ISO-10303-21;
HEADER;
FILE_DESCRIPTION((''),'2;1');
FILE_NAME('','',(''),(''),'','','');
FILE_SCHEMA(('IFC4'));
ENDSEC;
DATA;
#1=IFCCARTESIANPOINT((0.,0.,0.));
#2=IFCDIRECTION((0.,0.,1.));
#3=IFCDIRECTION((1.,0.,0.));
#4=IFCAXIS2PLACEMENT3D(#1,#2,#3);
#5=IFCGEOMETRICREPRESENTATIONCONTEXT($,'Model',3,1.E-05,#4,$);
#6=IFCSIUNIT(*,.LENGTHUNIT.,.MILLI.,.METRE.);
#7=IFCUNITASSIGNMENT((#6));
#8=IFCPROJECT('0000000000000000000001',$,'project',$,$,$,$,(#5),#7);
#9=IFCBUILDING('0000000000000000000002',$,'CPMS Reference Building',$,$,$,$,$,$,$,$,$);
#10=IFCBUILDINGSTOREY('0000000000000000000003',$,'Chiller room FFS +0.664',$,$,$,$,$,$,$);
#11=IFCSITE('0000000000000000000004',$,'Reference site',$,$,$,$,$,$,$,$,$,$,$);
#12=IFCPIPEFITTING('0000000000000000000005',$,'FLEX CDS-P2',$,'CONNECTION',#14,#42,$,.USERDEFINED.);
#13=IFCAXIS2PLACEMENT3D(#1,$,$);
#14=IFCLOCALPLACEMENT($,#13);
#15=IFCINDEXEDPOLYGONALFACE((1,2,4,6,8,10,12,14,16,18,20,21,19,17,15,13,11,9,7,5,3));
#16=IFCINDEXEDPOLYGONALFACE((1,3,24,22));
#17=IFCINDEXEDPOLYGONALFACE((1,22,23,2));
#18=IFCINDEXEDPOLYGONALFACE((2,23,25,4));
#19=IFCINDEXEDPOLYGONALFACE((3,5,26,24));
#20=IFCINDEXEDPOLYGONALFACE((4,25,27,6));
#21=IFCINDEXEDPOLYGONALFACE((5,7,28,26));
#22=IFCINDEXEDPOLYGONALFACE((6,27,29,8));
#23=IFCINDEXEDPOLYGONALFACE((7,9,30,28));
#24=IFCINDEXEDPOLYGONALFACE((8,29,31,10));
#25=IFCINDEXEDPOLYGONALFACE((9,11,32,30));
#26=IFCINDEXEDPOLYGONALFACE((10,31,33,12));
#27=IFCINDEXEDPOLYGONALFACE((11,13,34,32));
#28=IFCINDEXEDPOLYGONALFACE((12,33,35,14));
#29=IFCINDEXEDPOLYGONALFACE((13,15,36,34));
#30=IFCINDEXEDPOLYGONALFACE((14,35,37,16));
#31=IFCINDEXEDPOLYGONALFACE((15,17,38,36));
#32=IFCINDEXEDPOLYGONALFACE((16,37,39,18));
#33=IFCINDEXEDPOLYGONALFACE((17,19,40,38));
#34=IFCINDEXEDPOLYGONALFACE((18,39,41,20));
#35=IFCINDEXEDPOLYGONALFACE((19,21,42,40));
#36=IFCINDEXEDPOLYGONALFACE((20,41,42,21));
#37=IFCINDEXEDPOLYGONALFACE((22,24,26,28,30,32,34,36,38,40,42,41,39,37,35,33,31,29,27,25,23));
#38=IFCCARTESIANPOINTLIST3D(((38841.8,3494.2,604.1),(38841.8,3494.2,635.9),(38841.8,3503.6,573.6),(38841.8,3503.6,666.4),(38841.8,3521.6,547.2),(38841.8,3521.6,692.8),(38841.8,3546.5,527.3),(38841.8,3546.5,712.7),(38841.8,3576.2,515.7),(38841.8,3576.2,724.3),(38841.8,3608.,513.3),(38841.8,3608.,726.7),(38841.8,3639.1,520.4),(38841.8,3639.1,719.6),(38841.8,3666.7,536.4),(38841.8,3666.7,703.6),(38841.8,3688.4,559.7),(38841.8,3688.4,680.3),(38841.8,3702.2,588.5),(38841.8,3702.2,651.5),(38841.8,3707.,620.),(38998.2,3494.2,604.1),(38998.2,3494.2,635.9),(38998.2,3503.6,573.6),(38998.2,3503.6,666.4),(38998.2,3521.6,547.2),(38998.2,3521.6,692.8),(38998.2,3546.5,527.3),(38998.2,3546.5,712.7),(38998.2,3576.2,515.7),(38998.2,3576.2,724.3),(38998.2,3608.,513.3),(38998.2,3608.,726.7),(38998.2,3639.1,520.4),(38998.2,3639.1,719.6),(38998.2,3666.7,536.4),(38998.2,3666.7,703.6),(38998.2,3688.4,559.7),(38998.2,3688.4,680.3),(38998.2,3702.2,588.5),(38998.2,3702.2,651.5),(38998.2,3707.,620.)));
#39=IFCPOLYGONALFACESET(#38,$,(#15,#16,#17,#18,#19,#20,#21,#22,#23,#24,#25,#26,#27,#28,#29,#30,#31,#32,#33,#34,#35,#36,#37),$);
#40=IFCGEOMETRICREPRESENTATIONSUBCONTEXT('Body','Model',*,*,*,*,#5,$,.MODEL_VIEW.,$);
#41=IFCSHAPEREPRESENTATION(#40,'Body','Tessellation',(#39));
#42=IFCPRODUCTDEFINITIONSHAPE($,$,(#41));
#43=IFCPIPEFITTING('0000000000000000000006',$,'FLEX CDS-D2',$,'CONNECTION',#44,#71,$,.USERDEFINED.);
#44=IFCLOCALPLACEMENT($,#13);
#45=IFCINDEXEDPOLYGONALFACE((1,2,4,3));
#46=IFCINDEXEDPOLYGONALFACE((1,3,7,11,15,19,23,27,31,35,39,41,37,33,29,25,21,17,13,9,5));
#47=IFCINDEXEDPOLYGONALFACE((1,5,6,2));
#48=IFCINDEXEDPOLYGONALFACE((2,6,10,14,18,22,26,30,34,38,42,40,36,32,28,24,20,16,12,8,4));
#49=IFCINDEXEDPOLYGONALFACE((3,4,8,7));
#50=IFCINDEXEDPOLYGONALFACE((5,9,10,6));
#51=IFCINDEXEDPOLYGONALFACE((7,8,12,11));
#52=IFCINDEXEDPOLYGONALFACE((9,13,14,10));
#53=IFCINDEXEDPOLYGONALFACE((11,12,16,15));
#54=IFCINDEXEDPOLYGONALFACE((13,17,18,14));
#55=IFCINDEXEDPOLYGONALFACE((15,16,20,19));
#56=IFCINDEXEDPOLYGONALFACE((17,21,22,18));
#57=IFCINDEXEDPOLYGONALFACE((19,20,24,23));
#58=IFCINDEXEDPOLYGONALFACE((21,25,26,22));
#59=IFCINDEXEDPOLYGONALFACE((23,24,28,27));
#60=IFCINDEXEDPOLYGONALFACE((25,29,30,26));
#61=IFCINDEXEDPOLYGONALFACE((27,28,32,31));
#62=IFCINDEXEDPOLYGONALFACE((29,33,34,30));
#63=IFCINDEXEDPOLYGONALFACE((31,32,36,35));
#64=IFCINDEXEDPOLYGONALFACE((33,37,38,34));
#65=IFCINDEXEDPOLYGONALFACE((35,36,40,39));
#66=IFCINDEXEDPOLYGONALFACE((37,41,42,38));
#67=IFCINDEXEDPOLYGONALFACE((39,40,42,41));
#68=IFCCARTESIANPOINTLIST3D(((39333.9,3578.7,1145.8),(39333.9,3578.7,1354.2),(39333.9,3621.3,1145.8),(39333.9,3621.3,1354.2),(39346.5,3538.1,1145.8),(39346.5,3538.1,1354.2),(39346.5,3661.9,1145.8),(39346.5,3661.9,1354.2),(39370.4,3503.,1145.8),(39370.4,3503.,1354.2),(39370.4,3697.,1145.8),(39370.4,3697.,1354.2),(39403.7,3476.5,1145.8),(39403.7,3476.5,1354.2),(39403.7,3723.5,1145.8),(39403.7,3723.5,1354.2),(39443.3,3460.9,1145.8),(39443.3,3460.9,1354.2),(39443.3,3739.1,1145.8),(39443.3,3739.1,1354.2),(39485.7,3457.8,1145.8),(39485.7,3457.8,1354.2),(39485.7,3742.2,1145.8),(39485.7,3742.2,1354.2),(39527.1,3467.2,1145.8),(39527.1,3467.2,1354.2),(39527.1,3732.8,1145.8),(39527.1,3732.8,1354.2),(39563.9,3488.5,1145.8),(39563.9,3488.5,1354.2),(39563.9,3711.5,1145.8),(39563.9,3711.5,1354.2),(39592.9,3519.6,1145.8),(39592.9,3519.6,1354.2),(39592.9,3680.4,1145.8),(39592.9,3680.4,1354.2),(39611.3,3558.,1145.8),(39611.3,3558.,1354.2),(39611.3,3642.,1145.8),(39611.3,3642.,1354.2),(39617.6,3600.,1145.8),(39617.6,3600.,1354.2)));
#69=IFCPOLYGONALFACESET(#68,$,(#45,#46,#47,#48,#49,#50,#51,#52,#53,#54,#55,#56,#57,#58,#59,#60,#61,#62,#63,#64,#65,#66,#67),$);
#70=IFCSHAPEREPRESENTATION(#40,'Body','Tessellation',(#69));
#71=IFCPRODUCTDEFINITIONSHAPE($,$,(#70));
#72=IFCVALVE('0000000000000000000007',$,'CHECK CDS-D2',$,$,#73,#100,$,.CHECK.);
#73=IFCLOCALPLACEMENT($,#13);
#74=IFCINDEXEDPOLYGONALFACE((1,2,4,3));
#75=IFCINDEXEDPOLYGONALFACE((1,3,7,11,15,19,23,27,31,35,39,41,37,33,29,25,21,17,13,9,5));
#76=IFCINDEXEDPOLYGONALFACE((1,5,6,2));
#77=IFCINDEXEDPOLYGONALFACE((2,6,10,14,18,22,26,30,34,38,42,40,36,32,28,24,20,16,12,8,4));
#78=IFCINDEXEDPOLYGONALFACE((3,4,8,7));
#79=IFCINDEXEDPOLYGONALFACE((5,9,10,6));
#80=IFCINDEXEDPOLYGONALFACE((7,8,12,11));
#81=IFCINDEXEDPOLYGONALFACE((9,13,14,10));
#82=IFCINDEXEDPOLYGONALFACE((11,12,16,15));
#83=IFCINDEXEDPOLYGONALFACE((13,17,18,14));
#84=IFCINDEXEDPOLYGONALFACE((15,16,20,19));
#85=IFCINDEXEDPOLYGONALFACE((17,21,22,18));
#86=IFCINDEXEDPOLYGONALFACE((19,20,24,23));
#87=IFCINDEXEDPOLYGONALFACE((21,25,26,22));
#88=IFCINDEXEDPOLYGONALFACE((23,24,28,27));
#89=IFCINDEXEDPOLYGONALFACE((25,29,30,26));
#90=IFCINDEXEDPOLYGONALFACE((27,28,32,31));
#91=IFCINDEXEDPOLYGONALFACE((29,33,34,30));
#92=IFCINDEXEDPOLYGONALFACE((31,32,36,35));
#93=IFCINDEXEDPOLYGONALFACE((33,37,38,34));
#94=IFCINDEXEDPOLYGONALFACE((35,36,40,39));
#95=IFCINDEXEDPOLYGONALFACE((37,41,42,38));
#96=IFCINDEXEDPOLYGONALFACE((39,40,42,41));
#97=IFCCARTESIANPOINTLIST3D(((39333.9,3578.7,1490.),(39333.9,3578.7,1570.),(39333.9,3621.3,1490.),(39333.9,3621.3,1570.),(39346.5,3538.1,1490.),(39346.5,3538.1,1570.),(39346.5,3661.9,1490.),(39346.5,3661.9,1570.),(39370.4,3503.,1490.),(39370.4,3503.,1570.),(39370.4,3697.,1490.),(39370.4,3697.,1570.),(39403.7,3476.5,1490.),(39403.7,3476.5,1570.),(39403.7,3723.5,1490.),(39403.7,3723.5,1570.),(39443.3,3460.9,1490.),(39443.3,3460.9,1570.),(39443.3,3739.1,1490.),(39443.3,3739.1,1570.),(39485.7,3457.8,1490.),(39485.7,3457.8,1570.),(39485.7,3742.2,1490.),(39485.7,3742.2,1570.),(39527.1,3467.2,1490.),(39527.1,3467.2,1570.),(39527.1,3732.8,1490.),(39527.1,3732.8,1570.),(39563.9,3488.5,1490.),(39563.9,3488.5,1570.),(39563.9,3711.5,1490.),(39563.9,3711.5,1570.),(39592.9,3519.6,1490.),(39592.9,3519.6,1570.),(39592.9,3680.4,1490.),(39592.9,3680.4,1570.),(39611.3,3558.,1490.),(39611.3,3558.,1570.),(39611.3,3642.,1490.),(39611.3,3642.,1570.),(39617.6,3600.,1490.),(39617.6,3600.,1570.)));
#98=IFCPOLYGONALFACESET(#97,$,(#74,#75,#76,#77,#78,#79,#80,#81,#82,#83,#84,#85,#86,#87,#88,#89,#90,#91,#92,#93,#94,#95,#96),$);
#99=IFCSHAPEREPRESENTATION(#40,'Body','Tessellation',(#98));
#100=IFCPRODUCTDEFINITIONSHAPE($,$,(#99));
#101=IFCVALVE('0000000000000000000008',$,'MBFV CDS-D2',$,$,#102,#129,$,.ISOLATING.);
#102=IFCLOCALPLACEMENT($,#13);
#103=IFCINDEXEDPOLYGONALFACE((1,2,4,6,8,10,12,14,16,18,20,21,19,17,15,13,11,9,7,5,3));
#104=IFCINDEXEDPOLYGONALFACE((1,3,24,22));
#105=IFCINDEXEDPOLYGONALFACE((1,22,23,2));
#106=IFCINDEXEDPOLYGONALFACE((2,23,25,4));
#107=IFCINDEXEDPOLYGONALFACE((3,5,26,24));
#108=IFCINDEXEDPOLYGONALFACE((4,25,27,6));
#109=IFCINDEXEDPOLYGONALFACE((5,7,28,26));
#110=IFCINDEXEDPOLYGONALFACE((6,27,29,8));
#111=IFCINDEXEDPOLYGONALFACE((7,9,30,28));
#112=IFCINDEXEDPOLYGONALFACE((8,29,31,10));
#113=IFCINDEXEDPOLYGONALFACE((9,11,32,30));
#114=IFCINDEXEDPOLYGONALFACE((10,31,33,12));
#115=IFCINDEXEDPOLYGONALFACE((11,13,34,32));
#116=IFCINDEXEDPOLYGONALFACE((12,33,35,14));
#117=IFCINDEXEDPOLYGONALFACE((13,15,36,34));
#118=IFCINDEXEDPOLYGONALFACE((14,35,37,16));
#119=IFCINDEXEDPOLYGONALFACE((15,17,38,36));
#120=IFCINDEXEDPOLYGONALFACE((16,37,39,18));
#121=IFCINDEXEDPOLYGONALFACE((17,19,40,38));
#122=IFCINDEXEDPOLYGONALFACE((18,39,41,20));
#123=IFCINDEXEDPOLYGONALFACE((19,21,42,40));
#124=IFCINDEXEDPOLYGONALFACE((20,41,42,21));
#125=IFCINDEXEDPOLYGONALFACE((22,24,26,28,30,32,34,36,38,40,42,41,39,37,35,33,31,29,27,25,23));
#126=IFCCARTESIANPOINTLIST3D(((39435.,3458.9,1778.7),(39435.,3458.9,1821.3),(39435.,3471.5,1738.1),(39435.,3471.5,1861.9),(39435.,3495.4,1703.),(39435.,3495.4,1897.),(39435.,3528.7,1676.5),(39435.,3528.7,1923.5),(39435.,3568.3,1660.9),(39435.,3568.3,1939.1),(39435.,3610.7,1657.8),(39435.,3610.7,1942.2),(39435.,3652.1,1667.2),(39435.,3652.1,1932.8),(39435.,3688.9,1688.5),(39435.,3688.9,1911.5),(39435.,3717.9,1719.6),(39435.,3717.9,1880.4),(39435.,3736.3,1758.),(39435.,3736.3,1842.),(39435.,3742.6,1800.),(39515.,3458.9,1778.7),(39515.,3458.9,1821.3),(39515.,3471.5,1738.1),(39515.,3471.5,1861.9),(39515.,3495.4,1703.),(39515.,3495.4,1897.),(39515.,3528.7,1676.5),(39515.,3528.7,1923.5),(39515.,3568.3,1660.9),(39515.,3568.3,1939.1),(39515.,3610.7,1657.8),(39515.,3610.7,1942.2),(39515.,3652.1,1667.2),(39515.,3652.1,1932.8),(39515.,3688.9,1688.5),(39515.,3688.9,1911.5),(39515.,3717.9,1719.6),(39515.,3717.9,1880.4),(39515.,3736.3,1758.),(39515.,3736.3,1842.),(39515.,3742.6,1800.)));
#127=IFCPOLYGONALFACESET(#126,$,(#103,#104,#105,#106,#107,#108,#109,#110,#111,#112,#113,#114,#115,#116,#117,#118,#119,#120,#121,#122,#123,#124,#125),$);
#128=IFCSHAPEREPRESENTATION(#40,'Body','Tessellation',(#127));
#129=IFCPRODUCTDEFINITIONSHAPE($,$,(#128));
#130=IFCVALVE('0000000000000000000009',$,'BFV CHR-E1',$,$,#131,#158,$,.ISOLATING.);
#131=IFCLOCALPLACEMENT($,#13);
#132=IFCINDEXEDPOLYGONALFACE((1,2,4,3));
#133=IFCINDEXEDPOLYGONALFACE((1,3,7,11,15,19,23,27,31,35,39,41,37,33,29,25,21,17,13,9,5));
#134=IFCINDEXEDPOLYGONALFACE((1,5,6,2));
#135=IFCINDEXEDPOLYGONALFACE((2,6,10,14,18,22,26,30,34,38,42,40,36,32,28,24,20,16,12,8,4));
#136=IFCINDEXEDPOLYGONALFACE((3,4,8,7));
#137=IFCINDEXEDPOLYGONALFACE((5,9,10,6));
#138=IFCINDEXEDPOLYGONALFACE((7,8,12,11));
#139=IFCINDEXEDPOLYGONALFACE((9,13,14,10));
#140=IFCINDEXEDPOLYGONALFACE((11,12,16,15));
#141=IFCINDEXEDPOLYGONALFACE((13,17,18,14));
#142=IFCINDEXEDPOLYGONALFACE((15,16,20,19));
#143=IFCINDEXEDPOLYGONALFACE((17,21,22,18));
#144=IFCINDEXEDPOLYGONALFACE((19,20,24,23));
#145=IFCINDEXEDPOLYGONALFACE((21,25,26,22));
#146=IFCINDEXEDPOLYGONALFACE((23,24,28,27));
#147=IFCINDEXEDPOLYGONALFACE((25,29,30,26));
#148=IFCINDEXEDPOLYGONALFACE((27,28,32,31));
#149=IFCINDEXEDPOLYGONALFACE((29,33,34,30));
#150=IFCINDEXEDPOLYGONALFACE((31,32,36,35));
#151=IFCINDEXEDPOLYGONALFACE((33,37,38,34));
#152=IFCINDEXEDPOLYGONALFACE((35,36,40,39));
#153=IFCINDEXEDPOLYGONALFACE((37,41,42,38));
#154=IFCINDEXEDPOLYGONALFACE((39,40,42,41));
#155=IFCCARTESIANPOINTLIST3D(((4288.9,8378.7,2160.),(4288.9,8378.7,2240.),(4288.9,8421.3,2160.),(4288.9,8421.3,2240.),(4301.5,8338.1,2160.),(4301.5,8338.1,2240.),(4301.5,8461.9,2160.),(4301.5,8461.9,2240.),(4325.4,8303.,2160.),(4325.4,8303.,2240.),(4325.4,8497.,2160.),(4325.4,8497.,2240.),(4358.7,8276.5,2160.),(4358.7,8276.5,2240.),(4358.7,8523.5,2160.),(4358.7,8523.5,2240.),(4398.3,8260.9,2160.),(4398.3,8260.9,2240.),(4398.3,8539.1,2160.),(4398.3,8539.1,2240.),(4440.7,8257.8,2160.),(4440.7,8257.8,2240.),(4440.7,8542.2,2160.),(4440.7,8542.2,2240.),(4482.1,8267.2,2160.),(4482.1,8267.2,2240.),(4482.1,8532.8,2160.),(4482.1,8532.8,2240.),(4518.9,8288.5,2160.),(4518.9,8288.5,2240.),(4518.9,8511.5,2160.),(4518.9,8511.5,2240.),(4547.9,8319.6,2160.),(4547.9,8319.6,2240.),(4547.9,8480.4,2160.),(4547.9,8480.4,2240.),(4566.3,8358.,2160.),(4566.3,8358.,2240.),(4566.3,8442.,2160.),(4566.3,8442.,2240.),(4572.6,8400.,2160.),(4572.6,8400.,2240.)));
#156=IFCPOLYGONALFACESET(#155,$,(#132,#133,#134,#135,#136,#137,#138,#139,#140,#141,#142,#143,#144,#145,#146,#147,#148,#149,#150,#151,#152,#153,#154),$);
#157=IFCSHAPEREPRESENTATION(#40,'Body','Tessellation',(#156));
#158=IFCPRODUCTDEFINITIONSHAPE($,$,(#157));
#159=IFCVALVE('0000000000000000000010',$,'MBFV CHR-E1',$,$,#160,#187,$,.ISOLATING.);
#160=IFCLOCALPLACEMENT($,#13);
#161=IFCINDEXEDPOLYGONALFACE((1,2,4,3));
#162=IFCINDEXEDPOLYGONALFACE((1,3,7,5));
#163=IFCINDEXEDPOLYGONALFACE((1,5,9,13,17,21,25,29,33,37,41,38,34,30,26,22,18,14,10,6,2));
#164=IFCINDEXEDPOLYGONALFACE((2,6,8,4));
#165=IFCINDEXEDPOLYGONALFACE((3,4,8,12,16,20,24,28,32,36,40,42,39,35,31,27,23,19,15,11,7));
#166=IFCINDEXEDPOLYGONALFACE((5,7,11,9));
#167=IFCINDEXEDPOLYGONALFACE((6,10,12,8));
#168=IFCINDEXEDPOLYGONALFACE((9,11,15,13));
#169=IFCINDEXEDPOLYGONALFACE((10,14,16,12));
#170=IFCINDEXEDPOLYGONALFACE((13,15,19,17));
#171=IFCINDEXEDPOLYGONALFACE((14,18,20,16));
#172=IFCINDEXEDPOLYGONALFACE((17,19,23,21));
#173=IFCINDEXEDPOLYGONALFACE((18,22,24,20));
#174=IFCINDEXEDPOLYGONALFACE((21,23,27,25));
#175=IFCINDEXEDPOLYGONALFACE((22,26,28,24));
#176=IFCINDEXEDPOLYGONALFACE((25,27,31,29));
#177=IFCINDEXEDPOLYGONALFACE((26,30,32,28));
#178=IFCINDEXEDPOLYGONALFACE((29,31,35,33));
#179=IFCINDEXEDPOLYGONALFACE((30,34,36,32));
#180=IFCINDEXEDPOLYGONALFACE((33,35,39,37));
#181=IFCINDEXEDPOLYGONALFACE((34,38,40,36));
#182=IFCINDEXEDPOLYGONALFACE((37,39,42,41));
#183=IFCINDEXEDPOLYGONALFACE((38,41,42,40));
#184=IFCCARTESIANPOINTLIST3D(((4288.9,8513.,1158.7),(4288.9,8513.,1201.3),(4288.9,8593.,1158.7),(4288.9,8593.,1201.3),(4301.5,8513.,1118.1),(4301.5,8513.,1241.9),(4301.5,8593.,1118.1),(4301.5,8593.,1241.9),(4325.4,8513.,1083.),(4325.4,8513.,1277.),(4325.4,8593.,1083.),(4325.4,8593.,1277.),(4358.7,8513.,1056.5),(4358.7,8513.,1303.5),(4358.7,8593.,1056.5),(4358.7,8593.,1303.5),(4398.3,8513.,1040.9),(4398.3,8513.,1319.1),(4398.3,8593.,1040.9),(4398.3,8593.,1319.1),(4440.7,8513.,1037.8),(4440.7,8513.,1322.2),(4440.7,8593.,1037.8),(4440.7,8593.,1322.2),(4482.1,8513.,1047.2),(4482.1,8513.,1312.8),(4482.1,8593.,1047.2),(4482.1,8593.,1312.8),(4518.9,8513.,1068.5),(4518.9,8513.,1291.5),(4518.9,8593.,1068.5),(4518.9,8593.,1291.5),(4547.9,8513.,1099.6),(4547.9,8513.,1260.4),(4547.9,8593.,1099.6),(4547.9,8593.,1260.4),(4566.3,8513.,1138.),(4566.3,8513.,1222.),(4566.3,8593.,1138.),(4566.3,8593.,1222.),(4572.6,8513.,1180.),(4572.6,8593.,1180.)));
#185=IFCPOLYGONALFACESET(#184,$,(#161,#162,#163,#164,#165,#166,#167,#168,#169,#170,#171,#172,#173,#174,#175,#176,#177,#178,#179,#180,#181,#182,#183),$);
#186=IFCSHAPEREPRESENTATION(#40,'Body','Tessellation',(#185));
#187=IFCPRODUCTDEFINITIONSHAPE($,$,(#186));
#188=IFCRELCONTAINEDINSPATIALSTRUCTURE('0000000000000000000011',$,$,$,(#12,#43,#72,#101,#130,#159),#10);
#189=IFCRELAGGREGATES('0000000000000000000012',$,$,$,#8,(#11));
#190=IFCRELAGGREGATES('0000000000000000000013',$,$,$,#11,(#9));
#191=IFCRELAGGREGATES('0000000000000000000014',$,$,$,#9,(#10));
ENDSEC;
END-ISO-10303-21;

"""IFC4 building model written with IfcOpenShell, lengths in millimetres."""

from ifc_helpers import new_model, si_unit, frame, origin_with_axes, origin_2d, place, context, subcontext, project, spatial, circle_curve, outline, extrude, element, save


model = new_model("IFC4")

# Units and contexts
model_context = context("Model", 3, precision=1e-05, world=origin_with_axes())
body_context = subcontext(model_context, "Body", "Model", "MODEL_VIEW")
ifc_project = project(units=[si_unit("LENGTHUNIT", "METRE", prefix="MILLI")], contexts=[model_context])

# Site, building, storey
site = spatial("IfcSite", under=ifc_project, Name="Reference site")
building = spatial("IfcBuilding", under=site, Name="CPMS Reference Building")
storey = spatial("IfcBuildingStorey", under=building, Name="Chiller room FFS +0.664")

# Pipe fittings
pipe_fitting_1_placement = place(None, origin_with_axes())
element("IfcPipeFitting", 1, at=pipe_fitting_1_placement, inside=storey, Name="FLEX CDS-P2", ObjectType="CONNECTION", PredefinedType="USERDEFINED", context=body_context, shape_type="SweptSolid", body=[
    extrude(outline(circle_curve(origin_2d(), 107.0)), frame((38841.8, 3600.0, 620.0), z_axis=(1.0, 0.0, 0.0), x_axis=(0.0, 1.0, 0.0)), (0.0, 0.0, 1.0), 156.4),
])
pipe_fitting_2_placement = place(None, origin_with_axes())
element("IfcPipeFitting", 2, at=pipe_fitting_2_placement, inside=storey, Name="FLEX CDS-D2", ObjectType="CONNECTION", PredefinedType="USERDEFINED", context=body_context, shape_type="SweptSolid", body=[
    extrude(outline(circle_curve(origin_2d(), 142.6)), frame((39475.0, 3600.0, 1145.8), z_axis=(0.0, 0.0, 1.0), x_axis=(1.0, 0.0, 0.0)), (0.0, 0.0, 1.0), 208.5),
])

# Valves
valve_1_placement = place(None, origin_with_axes())
element("IfcValve", 3, at=valve_1_placement, inside=storey, Name="CHECK CDS-D2", PredefinedType="CHECK", context=body_context, shape_type="SweptSolid", body=[
    extrude(outline(circle_curve(origin_2d(), 142.6)), frame((39475.0, 3600.0, 1490.0), z_axis=(0.0, 0.0, 1.0), x_axis=(1.0, 0.0, 0.0)), (0.0, 0.0, 1.0), 80.0),
])
valve_2_placement = place(None, origin_with_axes())
element("IfcValve", 4, at=valve_2_placement, inside=storey, Name="MBFV CDS-D2", PredefinedType="ISOLATING", context=body_context, shape_type="SweptSolid", body=[
    extrude(outline(circle_curve(origin_2d(), 142.6)), frame((39435.0, 3600.0, 1800.0), z_axis=(1.0, 0.0, 0.0), x_axis=(0.0, 1.0, 0.0)), (0.0, 0.0, 1.0), 80.0),
])
valve_3_placement = place(None, origin_with_axes())
element("IfcValve", 5, at=valve_3_placement, inside=storey, Name="BFV CHR-E1", PredefinedType="ISOLATING", context=body_context, shape_type="SweptSolid", body=[
    extrude(outline(circle_curve(origin_2d(), 142.6)), frame((4430.0, 8400.0, 2240.0), z_axis=(0.0, 0.0, -1.0), x_axis=(1.0, 0.0, 0.0)), (0.0, 0.0, 1.0), 80.0),
])
valve_4_placement = place(None, origin_with_axes())
element("IfcValve", 6, at=valve_4_placement, inside=storey, Name="MBFV CHR-E1", PredefinedType="ISOLATING", context=body_context, shape_type="SweptSolid", body=[
    extrude(outline(circle_curve(origin_2d(), 142.6)), frame((4430.0, 8513.0, 1180.0), z_axis=(0.0, 1.0, 0.0), x_axis=(1.0, 0.0, 0.0)), (0.0, 0.0, 1.0), 80.0),
])

save(model, "model.ifc")
